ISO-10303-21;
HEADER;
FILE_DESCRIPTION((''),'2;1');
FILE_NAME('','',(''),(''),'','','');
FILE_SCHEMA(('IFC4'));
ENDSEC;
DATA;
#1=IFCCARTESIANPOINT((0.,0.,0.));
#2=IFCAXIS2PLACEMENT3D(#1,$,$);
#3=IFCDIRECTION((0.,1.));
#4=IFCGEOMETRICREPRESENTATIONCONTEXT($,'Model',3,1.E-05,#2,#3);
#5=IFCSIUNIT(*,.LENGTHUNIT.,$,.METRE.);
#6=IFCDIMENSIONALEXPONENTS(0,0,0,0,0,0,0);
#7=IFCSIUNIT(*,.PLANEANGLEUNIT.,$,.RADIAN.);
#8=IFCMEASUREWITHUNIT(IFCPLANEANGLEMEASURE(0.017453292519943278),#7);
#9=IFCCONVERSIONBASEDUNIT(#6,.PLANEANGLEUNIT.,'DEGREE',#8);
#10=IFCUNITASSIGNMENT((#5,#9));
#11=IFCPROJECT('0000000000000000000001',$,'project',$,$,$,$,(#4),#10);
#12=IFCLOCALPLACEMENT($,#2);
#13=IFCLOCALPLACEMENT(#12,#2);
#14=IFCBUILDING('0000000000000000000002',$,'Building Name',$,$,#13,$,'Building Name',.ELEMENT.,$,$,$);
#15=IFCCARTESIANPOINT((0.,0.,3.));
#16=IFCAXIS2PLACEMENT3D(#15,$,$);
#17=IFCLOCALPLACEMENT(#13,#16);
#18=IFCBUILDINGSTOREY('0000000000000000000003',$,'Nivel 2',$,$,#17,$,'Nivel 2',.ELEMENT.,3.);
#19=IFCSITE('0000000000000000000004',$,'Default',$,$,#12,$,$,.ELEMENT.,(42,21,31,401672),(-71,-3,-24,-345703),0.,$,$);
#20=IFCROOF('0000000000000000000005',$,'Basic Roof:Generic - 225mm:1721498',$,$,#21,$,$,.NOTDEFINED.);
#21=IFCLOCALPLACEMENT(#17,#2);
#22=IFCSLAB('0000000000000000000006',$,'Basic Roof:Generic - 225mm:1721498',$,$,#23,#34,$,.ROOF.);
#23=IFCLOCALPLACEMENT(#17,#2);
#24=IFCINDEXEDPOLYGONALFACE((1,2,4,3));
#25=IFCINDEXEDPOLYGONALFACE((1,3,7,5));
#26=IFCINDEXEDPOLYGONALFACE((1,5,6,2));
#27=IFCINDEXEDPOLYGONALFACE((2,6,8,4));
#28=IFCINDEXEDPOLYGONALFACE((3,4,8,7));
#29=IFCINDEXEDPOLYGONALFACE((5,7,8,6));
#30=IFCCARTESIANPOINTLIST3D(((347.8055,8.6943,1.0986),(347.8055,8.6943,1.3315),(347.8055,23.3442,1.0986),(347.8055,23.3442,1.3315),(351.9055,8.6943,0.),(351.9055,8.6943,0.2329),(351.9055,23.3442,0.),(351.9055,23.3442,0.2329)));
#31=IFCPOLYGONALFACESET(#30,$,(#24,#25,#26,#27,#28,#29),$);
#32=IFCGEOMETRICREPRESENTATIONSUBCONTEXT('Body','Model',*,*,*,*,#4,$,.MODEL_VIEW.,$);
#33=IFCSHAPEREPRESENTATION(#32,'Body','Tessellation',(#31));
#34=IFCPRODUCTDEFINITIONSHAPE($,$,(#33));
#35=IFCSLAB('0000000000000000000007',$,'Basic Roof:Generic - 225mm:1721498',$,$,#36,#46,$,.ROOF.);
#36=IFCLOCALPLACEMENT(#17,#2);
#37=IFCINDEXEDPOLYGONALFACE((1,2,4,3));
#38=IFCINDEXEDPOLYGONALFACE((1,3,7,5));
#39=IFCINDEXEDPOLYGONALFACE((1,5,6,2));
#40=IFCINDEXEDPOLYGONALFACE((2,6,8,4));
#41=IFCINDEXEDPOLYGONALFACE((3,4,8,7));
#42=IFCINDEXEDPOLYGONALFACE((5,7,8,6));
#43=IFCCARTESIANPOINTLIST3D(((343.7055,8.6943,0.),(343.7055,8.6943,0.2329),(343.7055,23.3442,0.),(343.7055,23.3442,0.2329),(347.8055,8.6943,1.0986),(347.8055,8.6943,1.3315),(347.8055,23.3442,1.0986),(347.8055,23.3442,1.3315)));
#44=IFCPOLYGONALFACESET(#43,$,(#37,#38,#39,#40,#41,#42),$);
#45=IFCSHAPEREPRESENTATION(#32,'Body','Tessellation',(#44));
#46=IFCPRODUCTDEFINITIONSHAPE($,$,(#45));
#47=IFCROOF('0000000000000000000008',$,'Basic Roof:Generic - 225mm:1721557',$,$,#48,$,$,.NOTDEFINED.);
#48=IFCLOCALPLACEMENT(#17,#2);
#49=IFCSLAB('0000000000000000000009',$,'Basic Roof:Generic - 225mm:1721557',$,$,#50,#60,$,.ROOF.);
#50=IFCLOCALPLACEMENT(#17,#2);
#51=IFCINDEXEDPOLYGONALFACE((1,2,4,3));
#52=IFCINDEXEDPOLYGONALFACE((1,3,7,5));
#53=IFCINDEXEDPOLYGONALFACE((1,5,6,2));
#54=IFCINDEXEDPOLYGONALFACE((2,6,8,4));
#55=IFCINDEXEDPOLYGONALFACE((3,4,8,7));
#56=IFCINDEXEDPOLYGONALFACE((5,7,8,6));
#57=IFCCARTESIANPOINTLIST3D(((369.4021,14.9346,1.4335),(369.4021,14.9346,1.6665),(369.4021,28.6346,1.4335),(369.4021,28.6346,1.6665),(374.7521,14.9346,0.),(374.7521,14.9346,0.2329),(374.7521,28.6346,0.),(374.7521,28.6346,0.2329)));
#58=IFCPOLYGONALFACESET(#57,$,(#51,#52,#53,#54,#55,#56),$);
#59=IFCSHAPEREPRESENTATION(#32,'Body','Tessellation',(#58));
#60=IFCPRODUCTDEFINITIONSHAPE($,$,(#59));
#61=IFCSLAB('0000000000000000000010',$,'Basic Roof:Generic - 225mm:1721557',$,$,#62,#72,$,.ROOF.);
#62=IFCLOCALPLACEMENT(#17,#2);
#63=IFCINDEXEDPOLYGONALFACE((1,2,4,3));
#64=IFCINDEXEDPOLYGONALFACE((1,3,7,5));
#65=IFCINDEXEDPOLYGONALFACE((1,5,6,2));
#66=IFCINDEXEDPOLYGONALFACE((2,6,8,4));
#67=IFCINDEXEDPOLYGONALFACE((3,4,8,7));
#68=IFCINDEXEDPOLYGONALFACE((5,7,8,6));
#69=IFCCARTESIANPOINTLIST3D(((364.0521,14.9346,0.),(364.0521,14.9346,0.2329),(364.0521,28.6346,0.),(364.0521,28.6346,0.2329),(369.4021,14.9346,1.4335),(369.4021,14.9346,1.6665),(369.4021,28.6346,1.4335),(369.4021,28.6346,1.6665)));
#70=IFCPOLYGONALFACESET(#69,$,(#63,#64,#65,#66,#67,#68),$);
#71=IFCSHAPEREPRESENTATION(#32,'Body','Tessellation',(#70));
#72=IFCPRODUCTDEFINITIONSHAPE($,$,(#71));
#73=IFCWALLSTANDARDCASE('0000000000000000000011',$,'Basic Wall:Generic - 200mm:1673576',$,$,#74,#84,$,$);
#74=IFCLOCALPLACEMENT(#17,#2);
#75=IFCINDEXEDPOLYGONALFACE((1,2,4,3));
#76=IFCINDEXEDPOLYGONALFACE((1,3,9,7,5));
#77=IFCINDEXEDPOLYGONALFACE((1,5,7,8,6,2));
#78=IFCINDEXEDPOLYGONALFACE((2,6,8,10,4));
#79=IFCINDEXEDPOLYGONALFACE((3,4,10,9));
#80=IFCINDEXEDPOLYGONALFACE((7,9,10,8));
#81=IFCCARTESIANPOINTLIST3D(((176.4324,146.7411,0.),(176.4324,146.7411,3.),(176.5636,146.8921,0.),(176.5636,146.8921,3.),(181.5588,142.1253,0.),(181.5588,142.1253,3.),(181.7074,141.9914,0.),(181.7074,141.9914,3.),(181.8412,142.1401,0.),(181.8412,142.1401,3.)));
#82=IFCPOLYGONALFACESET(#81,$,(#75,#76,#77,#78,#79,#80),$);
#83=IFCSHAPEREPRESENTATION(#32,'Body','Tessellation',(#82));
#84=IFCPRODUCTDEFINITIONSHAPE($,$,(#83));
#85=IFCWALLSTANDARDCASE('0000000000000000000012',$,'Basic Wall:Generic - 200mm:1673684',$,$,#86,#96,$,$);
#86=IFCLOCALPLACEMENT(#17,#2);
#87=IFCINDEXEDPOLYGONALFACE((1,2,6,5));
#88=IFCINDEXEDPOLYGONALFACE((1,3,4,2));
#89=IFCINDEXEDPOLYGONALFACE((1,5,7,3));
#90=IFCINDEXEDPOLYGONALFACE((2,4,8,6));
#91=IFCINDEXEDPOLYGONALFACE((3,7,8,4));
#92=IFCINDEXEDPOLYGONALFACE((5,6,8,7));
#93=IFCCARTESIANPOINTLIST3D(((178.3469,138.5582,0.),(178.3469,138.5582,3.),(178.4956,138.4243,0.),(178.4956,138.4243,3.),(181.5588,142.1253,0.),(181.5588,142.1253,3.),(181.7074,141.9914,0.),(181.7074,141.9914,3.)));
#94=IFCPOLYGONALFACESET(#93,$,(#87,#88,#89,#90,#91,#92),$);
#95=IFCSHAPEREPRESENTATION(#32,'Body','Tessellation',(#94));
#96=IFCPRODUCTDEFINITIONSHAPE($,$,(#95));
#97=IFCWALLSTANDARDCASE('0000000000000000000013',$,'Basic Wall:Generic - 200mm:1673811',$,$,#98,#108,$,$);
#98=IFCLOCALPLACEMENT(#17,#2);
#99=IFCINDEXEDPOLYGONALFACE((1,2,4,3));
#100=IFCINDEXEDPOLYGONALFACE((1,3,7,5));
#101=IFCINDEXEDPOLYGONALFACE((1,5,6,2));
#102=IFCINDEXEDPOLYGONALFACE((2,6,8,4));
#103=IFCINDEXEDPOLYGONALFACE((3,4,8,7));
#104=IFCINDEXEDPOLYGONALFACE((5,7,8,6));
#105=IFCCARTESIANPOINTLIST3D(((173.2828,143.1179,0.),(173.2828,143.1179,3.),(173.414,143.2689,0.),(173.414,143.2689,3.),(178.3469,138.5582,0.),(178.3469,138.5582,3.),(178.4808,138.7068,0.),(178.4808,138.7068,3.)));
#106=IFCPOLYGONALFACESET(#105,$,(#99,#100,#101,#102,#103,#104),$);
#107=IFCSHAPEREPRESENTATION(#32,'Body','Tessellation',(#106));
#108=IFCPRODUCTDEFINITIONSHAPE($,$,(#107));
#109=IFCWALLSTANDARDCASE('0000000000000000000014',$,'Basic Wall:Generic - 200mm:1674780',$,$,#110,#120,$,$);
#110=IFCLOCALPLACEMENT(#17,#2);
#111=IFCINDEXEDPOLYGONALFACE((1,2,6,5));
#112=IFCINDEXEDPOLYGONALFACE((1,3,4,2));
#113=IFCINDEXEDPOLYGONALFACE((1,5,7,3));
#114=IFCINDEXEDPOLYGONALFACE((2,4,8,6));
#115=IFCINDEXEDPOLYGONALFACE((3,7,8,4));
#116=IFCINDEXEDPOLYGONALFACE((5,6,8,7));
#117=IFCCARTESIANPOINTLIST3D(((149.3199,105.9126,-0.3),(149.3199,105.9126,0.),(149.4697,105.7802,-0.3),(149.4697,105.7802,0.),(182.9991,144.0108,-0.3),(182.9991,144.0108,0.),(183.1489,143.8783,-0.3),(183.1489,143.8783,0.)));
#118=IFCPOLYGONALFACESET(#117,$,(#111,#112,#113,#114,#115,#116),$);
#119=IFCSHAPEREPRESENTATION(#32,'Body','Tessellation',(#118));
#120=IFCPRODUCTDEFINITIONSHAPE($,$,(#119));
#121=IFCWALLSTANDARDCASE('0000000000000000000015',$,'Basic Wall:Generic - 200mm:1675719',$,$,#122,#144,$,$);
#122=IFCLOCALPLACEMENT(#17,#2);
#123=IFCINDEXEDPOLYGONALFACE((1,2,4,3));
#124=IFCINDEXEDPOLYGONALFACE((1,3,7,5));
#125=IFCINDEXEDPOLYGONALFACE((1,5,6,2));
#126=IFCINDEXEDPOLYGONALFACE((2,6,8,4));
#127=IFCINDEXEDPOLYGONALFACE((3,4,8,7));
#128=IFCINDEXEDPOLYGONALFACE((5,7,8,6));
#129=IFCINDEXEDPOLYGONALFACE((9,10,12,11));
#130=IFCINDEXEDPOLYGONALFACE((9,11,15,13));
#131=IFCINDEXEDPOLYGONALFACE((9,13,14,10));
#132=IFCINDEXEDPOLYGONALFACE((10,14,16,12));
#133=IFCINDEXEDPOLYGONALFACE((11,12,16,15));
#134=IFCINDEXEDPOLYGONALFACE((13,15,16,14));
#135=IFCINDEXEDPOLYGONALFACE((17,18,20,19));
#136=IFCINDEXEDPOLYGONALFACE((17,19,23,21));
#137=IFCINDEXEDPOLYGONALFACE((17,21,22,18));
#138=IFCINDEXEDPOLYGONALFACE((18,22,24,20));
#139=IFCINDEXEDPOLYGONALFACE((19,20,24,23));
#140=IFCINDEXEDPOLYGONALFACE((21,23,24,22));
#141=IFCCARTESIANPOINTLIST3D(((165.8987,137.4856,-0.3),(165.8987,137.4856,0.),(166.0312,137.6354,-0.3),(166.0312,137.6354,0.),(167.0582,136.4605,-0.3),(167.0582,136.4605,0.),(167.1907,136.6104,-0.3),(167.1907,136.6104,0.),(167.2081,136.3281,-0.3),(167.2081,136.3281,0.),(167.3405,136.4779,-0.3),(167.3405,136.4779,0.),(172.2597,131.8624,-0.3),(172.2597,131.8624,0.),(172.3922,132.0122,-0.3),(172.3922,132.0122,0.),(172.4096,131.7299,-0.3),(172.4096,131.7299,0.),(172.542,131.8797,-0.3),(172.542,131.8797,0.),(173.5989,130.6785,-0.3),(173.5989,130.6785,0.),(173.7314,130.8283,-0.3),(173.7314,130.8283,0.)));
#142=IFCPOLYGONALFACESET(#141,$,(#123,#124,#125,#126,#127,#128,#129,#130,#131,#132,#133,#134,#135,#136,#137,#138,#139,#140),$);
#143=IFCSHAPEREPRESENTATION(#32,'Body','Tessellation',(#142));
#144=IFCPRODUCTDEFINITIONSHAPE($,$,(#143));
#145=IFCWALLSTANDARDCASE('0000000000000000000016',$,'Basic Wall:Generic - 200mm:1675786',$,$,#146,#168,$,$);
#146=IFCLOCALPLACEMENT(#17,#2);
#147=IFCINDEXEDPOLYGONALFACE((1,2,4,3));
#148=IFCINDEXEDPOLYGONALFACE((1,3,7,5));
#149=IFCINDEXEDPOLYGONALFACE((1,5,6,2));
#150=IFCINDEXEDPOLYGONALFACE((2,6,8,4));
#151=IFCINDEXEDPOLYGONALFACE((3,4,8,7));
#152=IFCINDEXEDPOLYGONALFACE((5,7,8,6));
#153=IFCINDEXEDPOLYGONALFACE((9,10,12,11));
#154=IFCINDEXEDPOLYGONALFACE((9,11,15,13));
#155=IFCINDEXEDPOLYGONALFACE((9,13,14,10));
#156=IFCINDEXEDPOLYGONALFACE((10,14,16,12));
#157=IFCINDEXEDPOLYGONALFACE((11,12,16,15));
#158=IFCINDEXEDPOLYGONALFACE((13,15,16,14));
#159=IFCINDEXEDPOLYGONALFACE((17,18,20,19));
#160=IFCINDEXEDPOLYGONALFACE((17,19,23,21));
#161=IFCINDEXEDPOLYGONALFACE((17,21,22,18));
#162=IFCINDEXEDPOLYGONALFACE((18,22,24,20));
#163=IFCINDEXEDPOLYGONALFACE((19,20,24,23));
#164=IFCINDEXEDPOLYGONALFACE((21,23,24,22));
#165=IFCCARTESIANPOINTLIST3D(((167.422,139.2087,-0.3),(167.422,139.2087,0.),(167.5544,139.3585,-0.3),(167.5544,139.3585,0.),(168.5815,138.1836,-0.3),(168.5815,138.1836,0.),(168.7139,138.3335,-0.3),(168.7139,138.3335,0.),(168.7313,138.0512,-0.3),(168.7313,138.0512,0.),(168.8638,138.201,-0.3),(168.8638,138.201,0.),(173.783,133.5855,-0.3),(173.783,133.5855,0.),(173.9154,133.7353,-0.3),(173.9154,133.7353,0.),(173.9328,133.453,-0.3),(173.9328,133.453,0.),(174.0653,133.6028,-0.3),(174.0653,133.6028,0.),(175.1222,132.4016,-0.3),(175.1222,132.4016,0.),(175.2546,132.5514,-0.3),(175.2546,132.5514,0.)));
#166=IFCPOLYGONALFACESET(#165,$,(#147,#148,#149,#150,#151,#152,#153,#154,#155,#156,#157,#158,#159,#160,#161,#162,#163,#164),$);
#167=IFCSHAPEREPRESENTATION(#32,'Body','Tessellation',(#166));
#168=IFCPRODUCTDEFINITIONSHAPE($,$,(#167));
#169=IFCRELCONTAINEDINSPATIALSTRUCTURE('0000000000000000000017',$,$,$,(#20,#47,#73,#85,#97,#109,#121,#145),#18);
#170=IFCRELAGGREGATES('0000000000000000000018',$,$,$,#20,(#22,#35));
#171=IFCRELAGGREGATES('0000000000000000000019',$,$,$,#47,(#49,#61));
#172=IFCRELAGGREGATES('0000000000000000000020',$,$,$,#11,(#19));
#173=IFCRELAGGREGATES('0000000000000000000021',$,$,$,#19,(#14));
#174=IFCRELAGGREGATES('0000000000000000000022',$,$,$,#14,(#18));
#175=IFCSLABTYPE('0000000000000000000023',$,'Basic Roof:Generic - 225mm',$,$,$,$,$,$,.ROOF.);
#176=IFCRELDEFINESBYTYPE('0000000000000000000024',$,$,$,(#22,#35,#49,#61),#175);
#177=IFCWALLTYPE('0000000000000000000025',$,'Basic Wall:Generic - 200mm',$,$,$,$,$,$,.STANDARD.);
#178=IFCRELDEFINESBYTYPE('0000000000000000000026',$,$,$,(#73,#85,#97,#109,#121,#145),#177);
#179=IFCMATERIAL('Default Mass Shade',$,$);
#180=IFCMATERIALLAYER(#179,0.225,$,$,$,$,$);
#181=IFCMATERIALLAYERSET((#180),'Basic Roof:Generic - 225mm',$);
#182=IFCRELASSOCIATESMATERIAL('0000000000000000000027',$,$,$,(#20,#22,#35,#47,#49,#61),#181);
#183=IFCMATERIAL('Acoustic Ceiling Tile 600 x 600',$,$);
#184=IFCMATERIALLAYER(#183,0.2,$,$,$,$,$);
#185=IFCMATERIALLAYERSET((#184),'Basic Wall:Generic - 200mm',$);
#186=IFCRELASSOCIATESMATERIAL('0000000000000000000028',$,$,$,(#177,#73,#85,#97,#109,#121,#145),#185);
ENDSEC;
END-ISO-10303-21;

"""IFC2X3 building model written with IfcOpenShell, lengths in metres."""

from ifc_helpers import new_model, entity, si_unit, converted_unit, direction, frame, frame_2d, origin, origin_2d_with_axis, place, context, subcontext, project, spatial, polyline, rectangle, outline, extrude, material, layer, layer_set, layer_usage, type_object, element, aggregate, save


model = new_model("IFC2X3")

# Units and contexts
model_context = context("Model", 3, precision=1e-05, world=origin(), true_north=direction((0.0, 1.0)))
body_context = subcontext(model_context, "Body", "Model", "MODEL_VIEW")
ifc_project = project(units=[si_unit("LENGTHUNIT", "METRE"), converted_unit("PLANEANGLEUNIT", "DEGREE", entity("IfcPlaneAngleMeasure", 0.017453292519943278), si_unit("PLANEANGLEUNIT", "RADIAN"), dimensions=[0, 0, 0, 0, 0, 0, 0])], contexts=[model_context])

# Site, building, storey
site_placement = place(None, origin())
site = spatial("IfcSite", under=ifc_project, at=site_placement, Name="Default", CompositionType="ELEMENT", RefLatitude=(42, 21, 31, 401672), RefLongitude=(-71, -3, -24, -345703), RefElevation=0.0)
building_placement = place(site_placement, origin())
building = spatial("IfcBuilding", under=site, at=building_placement, Name="Building Name", LongName="Building Name", CompositionType="ELEMENT")
storey_placement = place(building_placement, frame((0.0, 0.0, 3.0)))
storey = spatial("IfcBuildingStorey", under=building, at=storey_placement, Name="Nivel 2", LongName="Nivel 2", CompositionType="ELEMENT", Elevation=3.0)

# Shared definitions
ifc_material_1 = material(Name="Default Mass Shade")
ifc_layer_1 = layer(ifc_material_1, 0.225)
ifc_layer_set_1 = layer_set([ifc_layer_1], Name="Basic Roof:Generic - 225mm")
slab_type = type_object("IfcSlabType", Name="Basic Roof:Generic - 225mm", PredefinedType="ROOF")

# Roofs, slabs
roof_1_placement = place(storey_placement, frame((343.7055, 8.6943, 0.0)))
roof_1 = element("IfcRoof", 1, at=roof_1_placement, inside=storey, material=ifc_layer_set_1, Name="Basic Roof:Generic - 225mm:1721498", ShapeType="NOTDEFINED")
slab_1_placement = place(roof_1_placement, origin())
slab_1 = element("IfcSlab", 2, at=slab_1_placement, type_object=slab_type, material=ifc_layer_set_1, Name="Basic Roof:Generic - 225mm:1721498", PredefinedType="ROOF", context=body_context, shape_type="SweptSolid", body=[
    extrude(rectangle(XDim=4.2446, YDim=14.65, at=origin_2d_with_axis()), frame((6.15, 7.325, 0.5493), z_axis=(0.258819, 0.0, 0.965926), x_axis=(0.965926, 0.0, -0.258819)), (-0.258819, 0.0, 0.965926), 0.2329),
])
slab_2_placement = place(roof_1_placement, origin())
slab_2 = element("IfcSlab", 3, at=slab_2_placement, type_object=slab_type, material=ifc_layer_set_1, Name="Basic Roof:Generic - 225mm:1721498", PredefinedType="ROOF", context=body_context, shape_type="SweptSolid", body=[
    extrude(rectangle(XDim=14.65, YDim=4.2446, at=frame_2d((0.0, 0.0), x_axis=(0.0, 1.0))), frame((2.05, 7.325, 0.5493), z_axis=(-0.258819, 0.0, 0.965926), x_axis=(0.965926, 0.0, 0.258819)), (0.258819, 0.0, 0.965926), 0.2329),
])
aggregate(roof_1, [slab_1, slab_2])
roof_2_placement = place(storey_placement, frame((364.0521, 14.9346, 0.0)))
roof_2 = element("IfcRoof", 4, at=roof_2_placement, inside=storey, material=ifc_layer_set_1, Name="Basic Roof:Generic - 225mm:1721557", ShapeType="NOTDEFINED")
slab_3_placement = place(roof_2_placement, origin())
slab_3 = element("IfcSlab", 5, at=slab_3_placement, type_object=slab_type, material=ifc_layer_set_1, Name="Basic Roof:Generic - 225mm:1721557", PredefinedType="ROOF", context=body_context, shape_type="SweptSolid", body=[
    extrude(rectangle(XDim=5.5387, YDim=13.7, at=frame_2d((0.0, 0.0), x_axis=(1.0, 0.0))), frame((8.025, 6.85, 0.7168), z_axis=(0.258819, 0.0, 0.965926), x_axis=(0.965926, 0.0, -0.258819)), (-0.258819, 0.0, 0.965926), 0.2329),
])
slab_4_placement = place(roof_2_placement, origin())
slab_4 = element("IfcSlab", 6, at=slab_4_placement, type_object=slab_type, material=ifc_layer_set_1, Name="Basic Roof:Generic - 225mm:1721557", PredefinedType="ROOF", context=body_context, shape_type="SweptSolid", body=[
    extrude(rectangle(XDim=13.7, YDim=5.5387, at=frame_2d((0.0, 0.0), x_axis=(0.0, 1.0))), frame((2.675, 6.85, 0.7168), z_axis=(-0.258819, 0.0, 0.965926), x_axis=(0.965926, 0.0, 0.258819)), (0.258819, 0.0, 0.965926), 0.2329),
])
aggregate(roof_2, [slab_3, slab_4])

# Walls
ifc_material_2 = material(Name="Acoustic Ceiling Tile 600 x 600")
ifc_layer_2 = layer(ifc_material_2, 0.2)
ifc_layer_set_2 = layer_set([ifc_layer_2], Name="Basic Wall:Generic - 200mm")
ifc_layer_usage_1 = layer_usage(ifc_layer_set_2, "AXIS2", "NEGATIVE", 0.1)
wall_type_1 = type_object("IfcWallType", Name="Basic Wall:Generic - 200mm", PredefinedType="STANDARD", material=ifc_layer_set_2)
wall_1_placement = place(storey_placement, frame((176.4967, 146.8177, 0.0), z_axis=(0.0, 0.0, 1.0), x_axis=(0.743145, -0.669131, 0.0)))
element("IfcWallStandardCase", 7, at=wall_1_placement, inside=storey, type_object=wall_type_1, material=ifc_layer_usage_1, Name="Basic Wall:Generic - 200mm:1673576", context=body_context, shape_type="SweptSolid", body=[
    extrude(outline(polyline([(7.1017, -0.1), (7.1017, 0.1), (0.0, 0.1), (0.0035, -0.1), (6.9017, -0.1), (7.1017, -0.1)])), origin(), (0.0, 0.0, 1.0), 3.0),
])
ifc_layer_usage_2 = layer_usage(ifc_layer_set_2, "AXIS2", "NEGATIVE", 0.1)
wall_2_placement = place(storey_placement, frame((181.6331, 142.0584, 0.0), z_axis=(0.0, 0.0, 1.0), x_axis=(-0.669131, -0.743145, 0.0)))
element("IfcWallStandardCase", 8, at=wall_2_placement, inside=storey, type_object=wall_type_1, material=ifc_layer_usage_2, Name="Basic Wall:Generic - 200mm:1673684", context=body_context, shape_type="SweptSolid", body=[
    extrude(rectangle(XDim=4.8, YDim=0.2, at=frame_2d((2.4, 0.0), x_axis=(-1.0, 0.0))), origin(), (0.0, 0.0, 1.0), 3.0),
])
ifc_layer_usage_3 = layer_usage(ifc_layer_set_2, "AXIS2", "NEGATIVE", 0.1)
wall_3_placement = place(storey_placement, frame((178.4138, 138.6325, 0.0), z_axis=(0.0, 0.0, 1.0), x_axis=(-0.743145, 0.669131, 0.0)))
element("IfcWallStandardCase", 9, at=wall_3_placement, inside=storey, type_object=wall_type_1, material=ifc_layer_usage_3, Name="Basic Wall:Generic - 200mm:1673811", context=body_context, shape_type="SweptSolid", body=[
    extrude(outline(polyline([(6.8179, -0.1), (6.8145, 0.1), (0.0, 0.1), (0.0, -0.1), (6.8179, -0.1)])), origin(), (0.0, 0.0, 1.0), 3.0),
])
ifc_layer_usage_4 = layer_usage(ifc_layer_set_2, "AXIS2", "NEGATIVE", 0.1)
wall_4_placement = place(storey_placement, frame((183.074, 143.9446, -0.3), z_axis=(0.0, 0.0, 1.0), x_axis=(-0.66232, -0.749221, 0.0)))
element("IfcWallStandardCase", 10, at=wall_4_placement, inside=storey, type_object=wall_type_1, material=ifc_layer_usage_4, Name="Basic Wall:Generic - 200mm:1674780", context=body_context, shape_type="SweptSolid", body=[
    extrude(rectangle(XDim=50.8503, YDim=0.2, at=frame_2d((25.4252, 0.0), x_axis=(-1.0, 0.0))), origin(), (0.0, 0.0, 1.0), 0.3),
])

# Walls, openings
ifc_layer_usage_5 = layer_usage(ifc_layer_set_2, "AXIS2", "NEGATIVE", 0.1)
wall_5_placement = place(storey_placement, frame((173.6651, 130.7534, -0.3), z_axis=(0.0, 0.0, 1.0), x_axis=(-0.749221, 0.66232, 0.0)))
wall_5 = element("IfcWallStandardCase", 11, at=wall_5_placement, inside=storey, type_object=wall_type_1, material=ifc_layer_usage_5, Name="Basic Wall:Generic - 200mm:1675719", context=body_context, shape_type="SweptSolid", body=[
    extrude(rectangle(XDim=10.2776, YDim=0.2, at=frame_2d((5.1388, 0.0), x_axis=(-1.0, 0.0))), origin(), (0.0, 0.0, 1.0), 0.3),
])
opening_1_placement = place(storey_placement, frame((173.6651, 130.7534, -0.3), z_axis=(0.0, 0.0, 1.0), x_axis=(-0.749221, 0.66232, 0.0)))
element("IfcOpeningElement", 12, at=opening_1_placement, cuts=wall_5, ObjectType="Opening", context=body_context, shape_type="SweptSolid", body=[
    extrude(rectangle(XDim=0.3, YDim=0.2, at=frame_2d((0.0, 0.0), x_axis=(1.0, 0.0))), frame((1.5874, 0.0, 0.15), z_axis=(1.0, 0.0, 0.0), x_axis=(0.0, 0.0, -1.0)), (0.0, 0.0, 1.0), 0.2),
])
opening_2_placement = place(storey_placement, frame((173.6651, 130.7534, -0.3), z_axis=(0.0, 0.0, 1.0), x_axis=(-0.749221, 0.66232, 0.0)))
element("IfcOpeningElement", 13, at=opening_2_placement, cuts=wall_5, ObjectType="Opening", context=body_context, shape_type="SweptSolid", body=[
    extrude(rectangle(XDim=0.3, YDim=0.2, at=frame_2d((0.0, 0.0), x_axis=(1.0, 0.0))), frame((8.73, 0.0, 0.15), z_axis=(-1.0, 0.0, 0.0), x_axis=(0.0, 0.0, 1.0)), (0.0, 0.0, 1.0), 0.2),
])
ifc_layer_usage_6 = layer_usage(ifc_layer_set_2, "AXIS2", "NEGATIVE", 0.1)
wall_6_placement = place(storey_placement, frame((175.1884, 132.4765, -0.3), z_axis=(0.0, 0.0, 1.0), x_axis=(-0.749221, 0.66232, 0.0)))
wall_6 = element("IfcWallStandardCase", 14, at=wall_6_placement, inside=storey, type_object=wall_type_1, material=ifc_layer_usage_6, Name="Basic Wall:Generic - 200mm:1675786", context=body_context, shape_type="SweptSolid", body=[
    extrude(rectangle(XDim=10.2776, YDim=0.2, at=frame_2d((5.1388, 0.0), x_axis=(-1.0, 0.0))), origin(), (0.0, 0.0, 1.0), 0.3),
])
opening_3_placement = place(storey_placement, frame((175.1884, 132.4765, -0.3), z_axis=(0.0, 0.0, 1.0), x_axis=(-0.749221, 0.66232, 0.0)))
element("IfcOpeningElement", 15, at=opening_3_placement, cuts=wall_6, ObjectType="Opening", context=body_context, shape_type="SweptSolid", body=[
    extrude(rectangle(XDim=0.3, YDim=0.2, at=frame_2d((0.0, 0.0), x_axis=(1.0, 0.0))), frame((1.7874, 0.0, 0.15), z_axis=(-1.0, 0.0, 0.0), x_axis=(0.0, 0.0, 1.0)), (0.0, 0.0, 1.0), 0.2),
])
opening_4_placement = place(storey_placement, frame((175.1884, 132.4765, -0.3), z_axis=(0.0, 0.0, 1.0), x_axis=(-0.749221, 0.66232, 0.0)))
element("IfcOpeningElement", 16, at=opening_4_placement, cuts=wall_6, ObjectType="Opening", context=body_context, shape_type="SweptSolid", body=[
    extrude(rectangle(XDim=0.3, YDim=0.2, at=frame_2d((0.0, 0.0), x_axis=(1.0, 0.0))), frame((8.53, 0.0, 0.15), z_axis=(1.0, 0.0, 0.0), x_axis=(0.0, 0.0, -1.0)), (0.0, 0.0, 1.0), 0.2),
])

save(model, "model.ifc")
